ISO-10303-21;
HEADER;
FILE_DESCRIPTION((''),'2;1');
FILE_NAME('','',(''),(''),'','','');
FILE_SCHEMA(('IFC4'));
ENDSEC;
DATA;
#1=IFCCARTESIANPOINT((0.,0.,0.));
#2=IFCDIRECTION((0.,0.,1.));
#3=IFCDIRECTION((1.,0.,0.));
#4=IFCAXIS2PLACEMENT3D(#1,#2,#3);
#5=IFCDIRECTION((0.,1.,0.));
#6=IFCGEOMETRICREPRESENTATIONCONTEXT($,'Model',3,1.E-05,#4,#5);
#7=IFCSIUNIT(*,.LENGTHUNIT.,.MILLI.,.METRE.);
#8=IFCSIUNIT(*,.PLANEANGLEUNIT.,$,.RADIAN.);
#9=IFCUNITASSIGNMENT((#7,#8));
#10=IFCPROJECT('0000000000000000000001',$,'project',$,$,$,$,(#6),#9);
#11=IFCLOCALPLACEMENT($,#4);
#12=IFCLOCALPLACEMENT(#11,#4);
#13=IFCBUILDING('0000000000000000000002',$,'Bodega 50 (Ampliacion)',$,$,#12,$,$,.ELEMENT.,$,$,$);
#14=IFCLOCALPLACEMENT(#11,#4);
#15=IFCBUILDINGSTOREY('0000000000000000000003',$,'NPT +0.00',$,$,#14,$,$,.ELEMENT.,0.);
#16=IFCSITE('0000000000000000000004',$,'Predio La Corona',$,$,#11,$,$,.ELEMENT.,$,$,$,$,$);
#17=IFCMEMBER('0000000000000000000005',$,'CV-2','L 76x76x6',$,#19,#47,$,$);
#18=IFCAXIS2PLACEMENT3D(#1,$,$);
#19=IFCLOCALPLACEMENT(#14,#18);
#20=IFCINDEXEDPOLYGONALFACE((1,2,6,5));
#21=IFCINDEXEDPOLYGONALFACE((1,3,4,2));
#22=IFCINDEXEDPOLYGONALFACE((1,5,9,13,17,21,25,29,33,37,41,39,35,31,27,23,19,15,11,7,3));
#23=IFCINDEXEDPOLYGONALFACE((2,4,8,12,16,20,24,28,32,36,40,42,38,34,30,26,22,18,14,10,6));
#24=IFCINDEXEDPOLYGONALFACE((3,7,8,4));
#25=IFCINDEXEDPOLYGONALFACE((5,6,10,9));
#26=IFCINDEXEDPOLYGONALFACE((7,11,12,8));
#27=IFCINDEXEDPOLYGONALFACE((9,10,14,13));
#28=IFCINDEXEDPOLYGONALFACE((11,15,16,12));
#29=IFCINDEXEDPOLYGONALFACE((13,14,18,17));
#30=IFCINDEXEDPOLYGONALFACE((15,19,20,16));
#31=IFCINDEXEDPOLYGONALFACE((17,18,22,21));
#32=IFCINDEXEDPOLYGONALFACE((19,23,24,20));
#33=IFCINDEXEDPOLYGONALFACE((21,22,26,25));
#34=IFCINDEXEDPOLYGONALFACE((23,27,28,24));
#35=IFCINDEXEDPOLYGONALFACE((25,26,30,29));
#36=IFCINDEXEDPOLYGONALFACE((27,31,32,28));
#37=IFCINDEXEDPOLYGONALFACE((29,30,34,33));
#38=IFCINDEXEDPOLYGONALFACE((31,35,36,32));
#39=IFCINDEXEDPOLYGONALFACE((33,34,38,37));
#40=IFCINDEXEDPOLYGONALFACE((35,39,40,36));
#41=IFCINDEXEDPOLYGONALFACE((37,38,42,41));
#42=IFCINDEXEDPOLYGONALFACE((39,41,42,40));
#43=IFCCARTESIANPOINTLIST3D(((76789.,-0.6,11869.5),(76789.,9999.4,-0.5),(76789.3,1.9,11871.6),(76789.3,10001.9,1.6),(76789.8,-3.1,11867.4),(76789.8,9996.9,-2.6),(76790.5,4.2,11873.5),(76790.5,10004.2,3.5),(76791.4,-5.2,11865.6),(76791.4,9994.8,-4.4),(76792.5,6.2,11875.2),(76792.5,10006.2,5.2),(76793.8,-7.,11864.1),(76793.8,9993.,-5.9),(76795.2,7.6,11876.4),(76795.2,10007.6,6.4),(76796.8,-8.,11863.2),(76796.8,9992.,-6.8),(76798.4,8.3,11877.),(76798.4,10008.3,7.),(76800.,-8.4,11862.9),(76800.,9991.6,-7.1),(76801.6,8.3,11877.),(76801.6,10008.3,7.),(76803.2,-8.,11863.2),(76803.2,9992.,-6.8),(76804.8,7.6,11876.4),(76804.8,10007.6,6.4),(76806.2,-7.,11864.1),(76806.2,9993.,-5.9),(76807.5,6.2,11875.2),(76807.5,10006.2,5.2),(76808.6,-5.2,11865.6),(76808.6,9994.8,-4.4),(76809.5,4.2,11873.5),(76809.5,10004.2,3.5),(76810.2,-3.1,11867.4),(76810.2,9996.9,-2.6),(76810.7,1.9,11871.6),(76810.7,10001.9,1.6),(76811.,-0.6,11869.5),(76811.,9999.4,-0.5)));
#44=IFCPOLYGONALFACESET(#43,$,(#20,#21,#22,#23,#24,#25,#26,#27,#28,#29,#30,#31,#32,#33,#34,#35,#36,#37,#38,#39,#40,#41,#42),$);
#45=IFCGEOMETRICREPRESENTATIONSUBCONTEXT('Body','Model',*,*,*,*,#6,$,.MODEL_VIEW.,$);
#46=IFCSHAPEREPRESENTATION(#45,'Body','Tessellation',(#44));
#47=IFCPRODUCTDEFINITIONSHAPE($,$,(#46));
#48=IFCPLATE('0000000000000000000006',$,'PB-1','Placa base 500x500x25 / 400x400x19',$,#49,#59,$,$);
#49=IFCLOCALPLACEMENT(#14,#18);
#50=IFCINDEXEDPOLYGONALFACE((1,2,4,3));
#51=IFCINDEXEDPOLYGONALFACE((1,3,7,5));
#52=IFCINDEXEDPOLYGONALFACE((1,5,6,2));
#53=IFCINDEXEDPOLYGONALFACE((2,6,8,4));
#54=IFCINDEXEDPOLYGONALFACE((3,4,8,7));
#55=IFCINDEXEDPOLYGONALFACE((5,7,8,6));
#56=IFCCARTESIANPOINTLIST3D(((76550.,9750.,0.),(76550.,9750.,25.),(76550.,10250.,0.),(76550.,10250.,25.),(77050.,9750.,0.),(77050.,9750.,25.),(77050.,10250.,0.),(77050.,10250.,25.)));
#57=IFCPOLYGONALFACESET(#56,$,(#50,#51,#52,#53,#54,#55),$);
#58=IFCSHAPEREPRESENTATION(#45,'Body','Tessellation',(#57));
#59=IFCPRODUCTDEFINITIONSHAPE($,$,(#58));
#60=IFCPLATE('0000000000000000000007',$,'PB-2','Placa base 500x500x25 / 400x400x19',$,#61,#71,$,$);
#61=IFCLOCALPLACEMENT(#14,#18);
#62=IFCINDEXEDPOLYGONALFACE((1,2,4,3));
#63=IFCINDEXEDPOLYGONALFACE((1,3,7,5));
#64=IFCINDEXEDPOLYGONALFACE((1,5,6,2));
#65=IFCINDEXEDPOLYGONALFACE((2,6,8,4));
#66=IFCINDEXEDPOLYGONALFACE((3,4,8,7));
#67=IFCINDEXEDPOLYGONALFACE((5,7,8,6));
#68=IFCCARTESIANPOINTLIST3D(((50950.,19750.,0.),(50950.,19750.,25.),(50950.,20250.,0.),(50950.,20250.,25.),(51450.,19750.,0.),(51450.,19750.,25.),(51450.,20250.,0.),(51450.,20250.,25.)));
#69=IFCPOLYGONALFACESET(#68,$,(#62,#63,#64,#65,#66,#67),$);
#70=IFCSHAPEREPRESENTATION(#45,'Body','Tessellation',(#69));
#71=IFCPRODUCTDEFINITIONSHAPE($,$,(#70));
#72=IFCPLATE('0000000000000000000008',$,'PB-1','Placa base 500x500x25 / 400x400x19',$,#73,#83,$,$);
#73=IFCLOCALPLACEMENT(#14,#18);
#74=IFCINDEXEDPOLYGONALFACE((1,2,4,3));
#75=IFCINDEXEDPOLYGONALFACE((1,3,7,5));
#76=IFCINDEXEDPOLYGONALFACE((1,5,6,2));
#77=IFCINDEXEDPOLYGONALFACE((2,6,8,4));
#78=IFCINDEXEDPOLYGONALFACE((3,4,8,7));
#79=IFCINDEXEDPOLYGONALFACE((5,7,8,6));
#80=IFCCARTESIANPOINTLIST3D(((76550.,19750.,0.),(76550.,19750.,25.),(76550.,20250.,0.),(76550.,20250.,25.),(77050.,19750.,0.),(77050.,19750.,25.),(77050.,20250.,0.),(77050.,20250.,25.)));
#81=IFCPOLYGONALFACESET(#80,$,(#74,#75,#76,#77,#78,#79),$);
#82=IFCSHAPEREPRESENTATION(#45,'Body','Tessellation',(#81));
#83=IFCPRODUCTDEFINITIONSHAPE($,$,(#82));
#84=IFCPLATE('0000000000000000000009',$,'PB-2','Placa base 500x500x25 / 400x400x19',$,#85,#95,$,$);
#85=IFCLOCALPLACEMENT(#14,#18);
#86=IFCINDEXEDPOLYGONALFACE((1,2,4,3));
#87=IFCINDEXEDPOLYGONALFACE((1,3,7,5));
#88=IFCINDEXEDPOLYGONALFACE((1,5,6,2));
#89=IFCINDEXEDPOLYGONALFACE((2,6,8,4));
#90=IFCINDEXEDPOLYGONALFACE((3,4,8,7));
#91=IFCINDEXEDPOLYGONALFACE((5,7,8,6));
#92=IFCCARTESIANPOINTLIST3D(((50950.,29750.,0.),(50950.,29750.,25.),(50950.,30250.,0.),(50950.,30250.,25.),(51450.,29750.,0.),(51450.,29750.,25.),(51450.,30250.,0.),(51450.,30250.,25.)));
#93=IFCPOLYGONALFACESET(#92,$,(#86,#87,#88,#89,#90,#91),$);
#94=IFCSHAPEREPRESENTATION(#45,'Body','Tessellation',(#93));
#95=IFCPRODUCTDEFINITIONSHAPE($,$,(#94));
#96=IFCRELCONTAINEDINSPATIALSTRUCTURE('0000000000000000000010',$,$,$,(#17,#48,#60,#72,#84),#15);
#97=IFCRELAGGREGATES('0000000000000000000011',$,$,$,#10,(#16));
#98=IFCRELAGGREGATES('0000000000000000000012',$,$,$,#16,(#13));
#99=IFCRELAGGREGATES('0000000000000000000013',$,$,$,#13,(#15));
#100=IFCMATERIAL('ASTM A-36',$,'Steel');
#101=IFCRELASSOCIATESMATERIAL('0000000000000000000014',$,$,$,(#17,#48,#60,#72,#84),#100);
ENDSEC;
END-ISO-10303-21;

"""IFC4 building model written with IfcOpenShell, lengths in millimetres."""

from ifc_helpers import new_model, si_unit, direction, frame, origin_with_axes, origin_2d, place, context, subcontext, project, spatial, rectangle, circle, extrude, material, element, save


model = new_model("IFC4")

# Units and contexts
model_context = context("Model", 3, precision=1e-05, world=origin_with_axes(), true_north=direction((0.0, 1.0, 0.0)))
body_context = subcontext(model_context, "Body", "Model", "MODEL_VIEW")
ifc_project = project(units=[si_unit("LENGTHUNIT", "METRE", prefix="MILLI"), si_unit("PLANEANGLEUNIT", "RADIAN")], contexts=[model_context])

# Site, building, storey
site_placement = place(None, origin_with_axes())
site = spatial("IfcSite", under=ifc_project, at=site_placement, Name="Predio La Corona", CompositionType="ELEMENT")
building_placement = place(site_placement, origin_with_axes())
building = spatial("IfcBuilding", under=site, at=building_placement, Name="Bodega 50 (Ampliacion)", CompositionType="ELEMENT")
storey_placement = place(site_placement, origin_with_axes())
storey = spatial("IfcBuildingStorey", under=building, at=storey_placement, Name="NPT +0.00", CompositionType="ELEMENT", Elevation=0.0)

# Shared definitions
ifc_material = material(Name="ASTM A-36", Category="Steel")

# Member
member_placement = place(storey_placement, frame((76800.0, 10000.0, 0.0), z_axis=(0.0, -0.644294, 0.764778), x_axis=(0.0, -0.764778, -0.644294)))
element("IfcMember", 1, at=member_placement, inside=storey, material=ifc_material, Name="CV-2", Description="L 76x76x6", context=body_context, shape_type="SweptSolid", body=[
    extrude(circle(Radius=11.0, at=origin_2d()), origin_with_axes(), (0.0, 0.0, 1.0), 15520.9),
])

# Plates
for number, where, z_axis, x_axis, name in (
    (2, (76800.0, 10000.0, 0.0), (0.0, 0.0, 1.0), (1.0, 0.0, 0.0), "PB-1"),
    (3, (51200.0, 20000.0, 0.0), (0.0, 0.0, 1.0), (1.0, 0.0, 0.0), "PB-2"),
    (4, (76800.0, 20000.0, 0.0), (0.0, 0.0, 1.0), (1.0, 0.0, 0.0), "PB-1"),
    (5, (51200.0, 30000.0, 0.0), (0.0, 0.0, 1.0), (1.0, 0.0, 0.0), "PB-2"),
):
    element("IfcPlate", number, at=place(storey_placement, frame(where, z_axis=z_axis, x_axis=x_axis)), inside=storey, material=ifc_material, Name=name, Description="Placa base 500x500x25 / 400x400x19", context=body_context, shape_type="SweptSolid", body=[
        extrude(rectangle(XDim=500.0, YDim=500.0, at=origin_2d()), origin_with_axes(), (0.0, 0.0, 1.0), 25.0),
    ])

save(model, "model.ifc")
